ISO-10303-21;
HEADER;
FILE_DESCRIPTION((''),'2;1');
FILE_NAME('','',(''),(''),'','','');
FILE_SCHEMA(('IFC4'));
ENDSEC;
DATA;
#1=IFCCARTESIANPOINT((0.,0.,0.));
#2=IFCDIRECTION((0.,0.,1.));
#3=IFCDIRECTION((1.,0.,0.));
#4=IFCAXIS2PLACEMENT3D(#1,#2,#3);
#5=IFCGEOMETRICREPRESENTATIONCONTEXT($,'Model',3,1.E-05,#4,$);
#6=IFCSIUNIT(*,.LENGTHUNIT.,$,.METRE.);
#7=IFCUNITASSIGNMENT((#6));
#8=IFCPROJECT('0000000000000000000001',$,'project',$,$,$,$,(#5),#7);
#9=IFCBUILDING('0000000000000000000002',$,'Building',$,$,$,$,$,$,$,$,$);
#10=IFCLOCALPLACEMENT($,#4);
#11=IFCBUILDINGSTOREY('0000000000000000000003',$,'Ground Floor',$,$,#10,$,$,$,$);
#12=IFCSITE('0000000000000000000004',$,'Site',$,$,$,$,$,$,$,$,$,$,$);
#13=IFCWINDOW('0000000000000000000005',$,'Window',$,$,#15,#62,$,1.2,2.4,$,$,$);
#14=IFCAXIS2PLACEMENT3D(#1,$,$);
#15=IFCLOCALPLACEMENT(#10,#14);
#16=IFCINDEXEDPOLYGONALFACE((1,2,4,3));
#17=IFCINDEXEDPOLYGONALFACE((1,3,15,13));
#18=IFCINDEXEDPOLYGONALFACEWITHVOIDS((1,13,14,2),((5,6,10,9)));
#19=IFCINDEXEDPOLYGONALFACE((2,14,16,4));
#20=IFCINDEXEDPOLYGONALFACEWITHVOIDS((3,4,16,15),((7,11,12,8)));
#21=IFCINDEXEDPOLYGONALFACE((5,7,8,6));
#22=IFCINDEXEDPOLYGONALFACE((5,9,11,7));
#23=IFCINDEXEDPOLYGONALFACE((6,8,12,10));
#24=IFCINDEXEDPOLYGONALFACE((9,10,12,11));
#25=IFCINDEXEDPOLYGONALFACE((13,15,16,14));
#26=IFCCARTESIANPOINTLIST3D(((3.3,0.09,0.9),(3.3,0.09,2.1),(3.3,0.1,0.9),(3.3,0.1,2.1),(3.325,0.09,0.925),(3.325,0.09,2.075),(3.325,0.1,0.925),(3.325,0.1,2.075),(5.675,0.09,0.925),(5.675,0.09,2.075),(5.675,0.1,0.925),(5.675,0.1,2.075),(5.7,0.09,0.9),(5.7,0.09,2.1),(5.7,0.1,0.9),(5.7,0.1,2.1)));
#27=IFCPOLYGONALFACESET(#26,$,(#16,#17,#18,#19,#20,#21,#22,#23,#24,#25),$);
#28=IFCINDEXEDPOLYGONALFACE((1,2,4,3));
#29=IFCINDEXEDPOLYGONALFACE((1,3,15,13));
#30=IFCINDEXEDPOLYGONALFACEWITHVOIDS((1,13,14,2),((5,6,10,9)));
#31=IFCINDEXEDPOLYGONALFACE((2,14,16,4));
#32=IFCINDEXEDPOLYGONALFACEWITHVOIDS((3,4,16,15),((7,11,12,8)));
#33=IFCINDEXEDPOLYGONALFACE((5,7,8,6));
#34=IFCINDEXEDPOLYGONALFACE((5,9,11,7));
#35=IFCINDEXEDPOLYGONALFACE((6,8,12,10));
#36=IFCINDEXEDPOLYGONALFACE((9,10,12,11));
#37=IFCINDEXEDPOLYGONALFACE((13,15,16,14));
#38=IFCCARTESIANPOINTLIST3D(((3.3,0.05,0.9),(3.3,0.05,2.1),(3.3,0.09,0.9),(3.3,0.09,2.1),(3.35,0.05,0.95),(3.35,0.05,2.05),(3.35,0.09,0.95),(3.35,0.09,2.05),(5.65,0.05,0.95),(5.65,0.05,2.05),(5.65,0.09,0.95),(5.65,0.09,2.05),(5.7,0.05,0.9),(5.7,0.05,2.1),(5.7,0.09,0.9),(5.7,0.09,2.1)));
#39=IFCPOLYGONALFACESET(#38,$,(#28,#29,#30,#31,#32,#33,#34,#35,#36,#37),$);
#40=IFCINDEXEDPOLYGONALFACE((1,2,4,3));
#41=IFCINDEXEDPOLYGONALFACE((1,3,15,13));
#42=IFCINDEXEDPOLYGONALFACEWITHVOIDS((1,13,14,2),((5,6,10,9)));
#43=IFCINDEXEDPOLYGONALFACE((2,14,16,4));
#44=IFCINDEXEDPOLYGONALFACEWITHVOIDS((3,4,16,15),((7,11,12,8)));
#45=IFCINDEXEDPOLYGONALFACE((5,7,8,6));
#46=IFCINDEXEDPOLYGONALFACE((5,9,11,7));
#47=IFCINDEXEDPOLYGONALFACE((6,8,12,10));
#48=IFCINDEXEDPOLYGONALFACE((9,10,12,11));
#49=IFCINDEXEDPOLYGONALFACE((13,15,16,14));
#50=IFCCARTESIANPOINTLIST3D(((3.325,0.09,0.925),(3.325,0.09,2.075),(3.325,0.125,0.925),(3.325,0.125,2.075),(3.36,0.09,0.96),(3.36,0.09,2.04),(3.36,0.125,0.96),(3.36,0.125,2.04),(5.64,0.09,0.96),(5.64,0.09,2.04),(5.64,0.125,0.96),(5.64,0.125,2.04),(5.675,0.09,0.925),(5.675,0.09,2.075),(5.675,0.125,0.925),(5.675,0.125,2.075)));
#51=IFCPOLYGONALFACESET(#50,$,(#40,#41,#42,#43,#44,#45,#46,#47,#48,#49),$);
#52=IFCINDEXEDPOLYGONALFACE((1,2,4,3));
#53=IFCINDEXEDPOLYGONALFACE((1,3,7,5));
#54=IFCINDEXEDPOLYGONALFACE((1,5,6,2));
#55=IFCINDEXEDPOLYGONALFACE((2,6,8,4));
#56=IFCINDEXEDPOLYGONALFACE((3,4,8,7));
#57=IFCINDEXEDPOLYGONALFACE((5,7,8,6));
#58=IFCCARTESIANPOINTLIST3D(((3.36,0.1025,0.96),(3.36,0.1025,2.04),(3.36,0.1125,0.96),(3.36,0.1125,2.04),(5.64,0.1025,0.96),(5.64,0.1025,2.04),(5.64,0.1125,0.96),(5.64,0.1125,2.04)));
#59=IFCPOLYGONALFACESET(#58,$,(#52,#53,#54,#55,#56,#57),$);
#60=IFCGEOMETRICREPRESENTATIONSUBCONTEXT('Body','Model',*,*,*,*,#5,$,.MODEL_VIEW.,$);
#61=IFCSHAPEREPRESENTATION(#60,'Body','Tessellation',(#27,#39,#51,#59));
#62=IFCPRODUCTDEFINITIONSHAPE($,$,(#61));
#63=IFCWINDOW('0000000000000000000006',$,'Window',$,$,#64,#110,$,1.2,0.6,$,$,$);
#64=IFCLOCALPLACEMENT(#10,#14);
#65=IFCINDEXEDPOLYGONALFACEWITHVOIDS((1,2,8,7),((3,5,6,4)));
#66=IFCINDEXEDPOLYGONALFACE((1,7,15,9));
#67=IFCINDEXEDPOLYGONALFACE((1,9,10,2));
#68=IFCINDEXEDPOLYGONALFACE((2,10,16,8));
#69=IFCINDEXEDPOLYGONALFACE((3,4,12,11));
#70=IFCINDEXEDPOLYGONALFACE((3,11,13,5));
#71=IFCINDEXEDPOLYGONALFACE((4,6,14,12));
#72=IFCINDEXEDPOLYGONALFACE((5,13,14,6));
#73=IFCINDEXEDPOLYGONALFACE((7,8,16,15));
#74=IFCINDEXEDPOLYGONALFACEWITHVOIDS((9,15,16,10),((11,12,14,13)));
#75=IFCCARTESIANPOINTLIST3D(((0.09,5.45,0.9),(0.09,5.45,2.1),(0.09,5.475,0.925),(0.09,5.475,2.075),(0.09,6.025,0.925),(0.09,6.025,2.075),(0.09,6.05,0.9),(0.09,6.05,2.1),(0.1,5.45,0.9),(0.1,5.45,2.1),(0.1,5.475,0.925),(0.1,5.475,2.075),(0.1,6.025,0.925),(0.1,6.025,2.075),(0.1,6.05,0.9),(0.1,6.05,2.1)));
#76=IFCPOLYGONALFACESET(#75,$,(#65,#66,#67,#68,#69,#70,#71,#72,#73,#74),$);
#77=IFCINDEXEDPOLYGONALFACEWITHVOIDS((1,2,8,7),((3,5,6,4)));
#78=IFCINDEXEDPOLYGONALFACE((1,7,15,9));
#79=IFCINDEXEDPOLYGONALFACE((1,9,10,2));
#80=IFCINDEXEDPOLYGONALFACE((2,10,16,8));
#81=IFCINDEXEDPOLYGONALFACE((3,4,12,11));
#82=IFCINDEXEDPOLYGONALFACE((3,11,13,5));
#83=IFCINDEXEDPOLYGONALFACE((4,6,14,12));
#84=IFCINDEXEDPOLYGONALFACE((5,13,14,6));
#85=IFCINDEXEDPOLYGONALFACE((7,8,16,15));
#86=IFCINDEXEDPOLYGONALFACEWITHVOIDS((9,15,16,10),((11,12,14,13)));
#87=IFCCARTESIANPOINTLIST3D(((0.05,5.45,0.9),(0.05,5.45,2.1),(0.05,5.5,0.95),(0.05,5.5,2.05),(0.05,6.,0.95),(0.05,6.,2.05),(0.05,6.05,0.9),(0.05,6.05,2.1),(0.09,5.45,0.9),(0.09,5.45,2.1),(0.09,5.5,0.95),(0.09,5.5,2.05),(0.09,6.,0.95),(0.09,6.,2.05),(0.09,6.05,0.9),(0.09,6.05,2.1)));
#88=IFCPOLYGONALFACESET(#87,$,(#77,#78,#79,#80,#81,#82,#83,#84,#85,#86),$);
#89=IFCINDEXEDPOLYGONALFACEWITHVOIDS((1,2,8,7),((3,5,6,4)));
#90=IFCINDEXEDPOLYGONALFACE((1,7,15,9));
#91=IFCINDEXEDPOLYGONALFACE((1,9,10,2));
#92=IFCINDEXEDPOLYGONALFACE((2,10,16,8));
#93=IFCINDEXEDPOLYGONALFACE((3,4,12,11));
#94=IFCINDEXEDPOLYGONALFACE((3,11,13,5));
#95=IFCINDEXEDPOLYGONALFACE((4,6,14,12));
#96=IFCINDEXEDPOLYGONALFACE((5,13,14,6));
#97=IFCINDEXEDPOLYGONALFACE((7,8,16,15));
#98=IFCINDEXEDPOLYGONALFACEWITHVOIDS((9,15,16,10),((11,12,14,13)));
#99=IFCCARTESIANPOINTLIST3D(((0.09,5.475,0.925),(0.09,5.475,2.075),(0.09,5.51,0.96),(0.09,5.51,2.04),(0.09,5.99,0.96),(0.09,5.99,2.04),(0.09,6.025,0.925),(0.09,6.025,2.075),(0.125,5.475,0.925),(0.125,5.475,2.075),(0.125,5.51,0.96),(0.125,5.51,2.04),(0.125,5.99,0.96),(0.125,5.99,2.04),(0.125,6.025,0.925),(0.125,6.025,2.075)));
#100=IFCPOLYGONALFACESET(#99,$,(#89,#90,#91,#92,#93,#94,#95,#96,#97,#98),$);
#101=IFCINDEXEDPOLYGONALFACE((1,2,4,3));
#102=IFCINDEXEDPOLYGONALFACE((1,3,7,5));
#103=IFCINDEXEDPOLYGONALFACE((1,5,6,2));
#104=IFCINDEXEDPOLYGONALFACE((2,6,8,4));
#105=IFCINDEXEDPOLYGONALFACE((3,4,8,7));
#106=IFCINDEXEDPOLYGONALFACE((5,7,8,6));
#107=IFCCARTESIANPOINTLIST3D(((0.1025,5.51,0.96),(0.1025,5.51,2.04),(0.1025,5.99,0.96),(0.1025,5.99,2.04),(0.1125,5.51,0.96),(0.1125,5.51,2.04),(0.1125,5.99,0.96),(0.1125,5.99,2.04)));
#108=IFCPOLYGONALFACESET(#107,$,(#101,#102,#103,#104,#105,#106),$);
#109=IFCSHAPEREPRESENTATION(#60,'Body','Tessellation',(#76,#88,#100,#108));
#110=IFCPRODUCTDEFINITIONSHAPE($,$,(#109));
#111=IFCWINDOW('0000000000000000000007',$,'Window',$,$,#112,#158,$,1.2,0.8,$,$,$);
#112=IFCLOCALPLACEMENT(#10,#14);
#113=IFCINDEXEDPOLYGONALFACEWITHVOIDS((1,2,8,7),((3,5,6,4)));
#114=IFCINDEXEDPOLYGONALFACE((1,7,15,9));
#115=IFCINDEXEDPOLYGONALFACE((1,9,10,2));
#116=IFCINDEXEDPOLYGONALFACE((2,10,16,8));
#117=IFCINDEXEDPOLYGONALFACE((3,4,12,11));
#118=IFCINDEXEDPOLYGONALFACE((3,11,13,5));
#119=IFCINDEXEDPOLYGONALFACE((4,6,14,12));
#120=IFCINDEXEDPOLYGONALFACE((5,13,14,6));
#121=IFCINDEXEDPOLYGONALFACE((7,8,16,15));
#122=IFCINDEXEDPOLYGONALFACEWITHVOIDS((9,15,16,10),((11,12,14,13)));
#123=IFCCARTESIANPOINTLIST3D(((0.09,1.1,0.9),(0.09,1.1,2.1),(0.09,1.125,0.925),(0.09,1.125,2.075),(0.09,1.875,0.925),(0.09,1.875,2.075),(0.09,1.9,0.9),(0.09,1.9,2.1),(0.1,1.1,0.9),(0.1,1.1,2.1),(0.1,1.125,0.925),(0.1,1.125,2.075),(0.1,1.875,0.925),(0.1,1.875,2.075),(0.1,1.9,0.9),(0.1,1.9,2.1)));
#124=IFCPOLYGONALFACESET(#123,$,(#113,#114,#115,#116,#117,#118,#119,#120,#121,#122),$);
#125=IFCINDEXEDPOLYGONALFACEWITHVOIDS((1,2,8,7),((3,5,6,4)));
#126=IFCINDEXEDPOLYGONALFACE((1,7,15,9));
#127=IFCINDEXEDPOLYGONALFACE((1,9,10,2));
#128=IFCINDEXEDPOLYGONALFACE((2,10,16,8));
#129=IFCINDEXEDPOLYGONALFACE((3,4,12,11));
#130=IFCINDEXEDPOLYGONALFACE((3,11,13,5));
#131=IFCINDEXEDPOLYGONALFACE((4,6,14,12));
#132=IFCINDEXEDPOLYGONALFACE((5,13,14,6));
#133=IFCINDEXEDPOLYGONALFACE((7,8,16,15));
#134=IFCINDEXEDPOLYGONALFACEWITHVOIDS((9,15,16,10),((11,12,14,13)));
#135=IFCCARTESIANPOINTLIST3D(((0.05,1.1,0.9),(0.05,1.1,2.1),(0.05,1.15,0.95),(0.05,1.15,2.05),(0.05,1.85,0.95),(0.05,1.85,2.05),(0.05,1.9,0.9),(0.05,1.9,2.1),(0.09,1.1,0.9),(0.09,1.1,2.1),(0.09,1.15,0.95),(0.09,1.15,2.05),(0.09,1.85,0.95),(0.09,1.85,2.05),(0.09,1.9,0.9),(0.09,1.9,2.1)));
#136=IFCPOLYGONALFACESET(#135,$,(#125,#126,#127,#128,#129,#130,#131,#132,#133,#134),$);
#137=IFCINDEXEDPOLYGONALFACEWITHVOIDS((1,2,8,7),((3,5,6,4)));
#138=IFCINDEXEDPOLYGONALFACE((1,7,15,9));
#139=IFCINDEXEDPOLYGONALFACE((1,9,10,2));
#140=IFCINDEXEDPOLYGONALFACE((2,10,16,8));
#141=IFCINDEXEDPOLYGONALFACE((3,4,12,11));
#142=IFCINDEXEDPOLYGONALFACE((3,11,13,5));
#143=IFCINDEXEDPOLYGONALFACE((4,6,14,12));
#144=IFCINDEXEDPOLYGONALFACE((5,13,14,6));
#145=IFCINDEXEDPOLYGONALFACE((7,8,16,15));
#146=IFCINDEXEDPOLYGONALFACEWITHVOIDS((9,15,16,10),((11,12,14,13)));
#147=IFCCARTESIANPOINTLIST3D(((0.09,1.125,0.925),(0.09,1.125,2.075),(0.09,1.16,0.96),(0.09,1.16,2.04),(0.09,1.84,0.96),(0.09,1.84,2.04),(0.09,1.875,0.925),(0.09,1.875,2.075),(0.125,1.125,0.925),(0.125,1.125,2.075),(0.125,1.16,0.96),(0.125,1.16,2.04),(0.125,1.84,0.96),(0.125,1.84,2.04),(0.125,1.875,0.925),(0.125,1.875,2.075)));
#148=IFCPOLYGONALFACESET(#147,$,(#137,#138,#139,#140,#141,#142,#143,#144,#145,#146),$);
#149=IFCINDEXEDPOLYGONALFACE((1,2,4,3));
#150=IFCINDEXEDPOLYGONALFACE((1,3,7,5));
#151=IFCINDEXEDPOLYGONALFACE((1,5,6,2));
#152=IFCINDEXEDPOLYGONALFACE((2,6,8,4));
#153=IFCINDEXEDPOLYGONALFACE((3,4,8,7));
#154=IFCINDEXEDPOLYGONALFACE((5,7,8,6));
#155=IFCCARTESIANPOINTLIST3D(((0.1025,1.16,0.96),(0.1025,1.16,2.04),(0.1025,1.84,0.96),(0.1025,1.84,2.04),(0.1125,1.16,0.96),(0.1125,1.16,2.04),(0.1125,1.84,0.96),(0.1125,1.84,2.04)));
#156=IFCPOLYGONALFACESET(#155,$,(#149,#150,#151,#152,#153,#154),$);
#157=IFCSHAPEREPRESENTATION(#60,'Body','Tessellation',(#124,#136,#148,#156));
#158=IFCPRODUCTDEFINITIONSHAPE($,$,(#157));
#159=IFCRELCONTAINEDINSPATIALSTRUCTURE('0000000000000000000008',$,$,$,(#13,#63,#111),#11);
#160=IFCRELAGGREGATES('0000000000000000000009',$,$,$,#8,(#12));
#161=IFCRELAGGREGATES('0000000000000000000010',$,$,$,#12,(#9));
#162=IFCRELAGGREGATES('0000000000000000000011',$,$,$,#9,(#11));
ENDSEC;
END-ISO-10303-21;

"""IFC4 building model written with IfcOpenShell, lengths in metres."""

from ifc_helpers import new_model, si_unit, frame, origin_with_axes, place, context, subcontext, project, spatial, line, indexed_curve, outline, extrude, element, save


model = new_model("IFC4")

# Units and contexts
model_context = context("Model", 3, precision=1e-05, world=origin_with_axes())
body_context = subcontext(model_context, "Body", "Model", "MODEL_VIEW")
ifc_project = project(units=[si_unit("LENGTHUNIT", "METRE")], contexts=[model_context])

# Site, building, storey
site = spatial("IfcSite", under=ifc_project, Name="Site")
building = spatial("IfcBuilding", under=site, Name="Building")
storey_placement = place(None, origin_with_axes())
storey = spatial("IfcBuildingStorey", under=building, at=storey_placement, Name="Ground Floor")

# Windows
window_1_placement = place(storey_placement, frame((3.3, 0.0, 0.9), z_axis=(0.0, 0.0, 1.0), x_axis=(1.0, 0.0, 0.0)))
element("IfcWindow", 1, at=window_1_placement, inside=storey, Name="Window", OverallHeight=1.2, OverallWidth=2.4, context=body_context, shape_type="SweptSolid", body=[
    extrude(outline(indexed_curve([(0.0, 0.0), (2.4, 0.0), (2.4, 1.2), (0.0, 1.2)], segments=[line(1, 2, 3, 4, 1)]), holes=[indexed_curve([(0.025, 0.025), (2.375, 0.025), (2.375, 1.175), (0.025, 1.175)], segments=[line(1, 2, 3, 4, 1)])]), frame((0.0, 0.09, 0.0), z_axis=(0.0, -1.0, 0.0), x_axis=(1.0, 0.0, 0.0)), (0.0, 0.0, -1.0), 0.01),
    extrude(outline(indexed_curve([(0.0, 0.0), (2.4, 0.0), (2.4, 1.2), (0.0, 1.2)], segments=[line(1, 2, 3, 4, 1)]), holes=[indexed_curve([(0.05, 0.05), (2.35, 0.05), (2.35, 1.15), (0.05, 1.15)], segments=[line(1, 2, 3, 4, 1)])]), frame((0.0, 0.05, 0.0), z_axis=(0.0, -1.0, 0.0), x_axis=(1.0, 0.0, 0.0)), (0.0, 0.0, -1.0), 0.04),
    extrude(outline(indexed_curve([(0.0, 0.0), (2.35, 0.0), (2.35, 1.15), (0.0, 1.15)], segments=[line(1, 2, 3, 4, 1)]), holes=[indexed_curve([(0.035, 0.035), (2.315, 0.035), (2.315, 1.115), (0.035, 1.115)], segments=[line(1, 2, 3, 4, 1)])]), frame((0.025, 0.09, 0.025), z_axis=(0.0, -1.0, 0.0), x_axis=(1.0, 0.0, 0.0)), (0.0, 0.0, -1.0), 0.035),
    extrude(outline(indexed_curve([(0.035, 0.035), (2.315, 0.035), (2.315, 1.115), (0.035, 1.115)], segments=[line(1, 2, 3, 4, 1)])), frame((0.025, 0.1025, 0.025), z_axis=(0.0, -1.0, 0.0), x_axis=(1.0, 0.0, 0.0)), (0.0, 0.0, -1.0), 0.01),
])
window_2_placement = place(storey_placement, frame((0.0, 6.05, 0.9), z_axis=(0.0, 0.0, 1.0), x_axis=(0.0, -1.0, 0.0)))
element("IfcWindow", 2, at=window_2_placement, inside=storey, Name="Window", OverallHeight=1.2, OverallWidth=0.6, context=body_context, shape_type="SweptSolid", body=[
    extrude(outline(indexed_curve([(0.0, 0.0), (0.6, 0.0), (0.6, 1.2), (0.0, 1.2)], segments=[line(1, 2, 3, 4, 1)]), holes=[indexed_curve([(0.025, 0.025), (0.575, 0.025), (0.575, 1.175), (0.025, 1.175)], segments=[line(1, 2, 3, 4, 1)])]), frame((0.0, 0.09, 0.0), z_axis=(0.0, -1.0, 0.0), x_axis=(1.0, 0.0, 0.0)), (0.0, 0.0, -1.0), 0.01),
    extrude(outline(indexed_curve([(0.0, 0.0), (0.6, 0.0), (0.6, 1.2), (0.0, 1.2)], segments=[line(1, 2, 3, 4, 1)]), holes=[indexed_curve([(0.05, 0.05), (0.55, 0.05), (0.55, 1.15), (0.05, 1.15)], segments=[line(1, 2, 3, 4, 1)])]), frame((0.0, 0.05, 0.0), z_axis=(0.0, -1.0, 0.0), x_axis=(1.0, 0.0, 0.0)), (0.0, 0.0, -1.0), 0.04),
    extrude(outline(indexed_curve([(0.0, 0.0), (0.55, 0.0), (0.55, 1.15), (0.0, 1.15)], segments=[line(1, 2, 3, 4, 1)]), holes=[indexed_curve([(0.035, 0.035), (0.515, 0.035), (0.515, 1.115), (0.035, 1.115)], segments=[line(1, 2, 3, 4, 1)])]), frame((0.025, 0.09, 0.025), z_axis=(0.0, -1.0, 0.0), x_axis=(1.0, 0.0, 0.0)), (0.0, 0.0, -1.0), 0.035),
    extrude(outline(indexed_curve([(0.035, 0.035), (0.515, 0.035), (0.515, 1.115), (0.035, 1.115)], segments=[line(1, 2, 3, 4, 1)])), frame((0.025, 0.1025, 0.025), z_axis=(0.0, -1.0, 0.0), x_axis=(1.0, 0.0, 0.0)), (0.0, 0.0, -1.0), 0.01),
])
window_3_placement = place(storey_placement, frame((0.0, 1.9, 0.9), z_axis=(0.0, 0.0, 1.0), x_axis=(0.0, -1.0, 0.0)))
element("IfcWindow", 3, at=window_3_placement, inside=storey, Name="Window", OverallHeight=1.2, OverallWidth=0.8, context=body_context, shape_type="SweptSolid", body=[
    extrude(outline(indexed_curve([(0.0, 0.0), (0.8, 0.0), (0.8, 1.2), (0.0, 1.2)], segments=[line(1, 2, 3, 4, 1)]), holes=[indexed_curve([(0.025, 0.025), (0.775, 0.025), (0.775, 1.175), (0.025, 1.175)], segments=[line(1, 2, 3, 4, 1)])]), frame((0.0, 0.09, 0.0), z_axis=(0.0, -1.0, 0.0), x_axis=(1.0, 0.0, 0.0)), (0.0, 0.0, -1.0), 0.01),
    extrude(outline(indexed_curve([(0.0, 0.0), (0.8, 0.0), (0.8, 1.2), (0.0, 1.2)], segments=[line(1, 2, 3, 4, 1)]), holes=[indexed_curve([(0.05, 0.05), (0.75, 0.05), (0.75, 1.15), (0.05, 1.15)], segments=[line(1, 2, 3, 4, 1)])]), frame((0.0, 0.05, 0.0), z_axis=(0.0, -1.0, 0.0), x_axis=(1.0, 0.0, 0.0)), (0.0, 0.0, -1.0), 0.04),
    extrude(outline(indexed_curve([(0.0, 0.0), (0.75, 0.0), (0.75, 1.15), (0.0, 1.15)], segments=[line(1, 2, 3, 4, 1)]), holes=[indexed_curve([(0.035, 0.035), (0.715, 0.035), (0.715, 1.115), (0.035, 1.115)], segments=[line(1, 2, 3, 4, 1)])]), frame((0.025, 0.09, 0.025), z_axis=(0.0, -1.0, 0.0), x_axis=(1.0, 0.0, 0.0)), (0.0, 0.0, -1.0), 0.035),
    extrude(outline(indexed_curve([(0.035, 0.035), (0.715, 0.035), (0.715, 1.115), (0.035, 1.115)], segments=[line(1, 2, 3, 4, 1)])), frame((0.025, 0.1025, 0.025), z_axis=(0.0, -1.0, 0.0), x_axis=(1.0, 0.0, 0.0)), (0.0, 0.0, -1.0), 0.01),
])

save(model, "model.ifc")
